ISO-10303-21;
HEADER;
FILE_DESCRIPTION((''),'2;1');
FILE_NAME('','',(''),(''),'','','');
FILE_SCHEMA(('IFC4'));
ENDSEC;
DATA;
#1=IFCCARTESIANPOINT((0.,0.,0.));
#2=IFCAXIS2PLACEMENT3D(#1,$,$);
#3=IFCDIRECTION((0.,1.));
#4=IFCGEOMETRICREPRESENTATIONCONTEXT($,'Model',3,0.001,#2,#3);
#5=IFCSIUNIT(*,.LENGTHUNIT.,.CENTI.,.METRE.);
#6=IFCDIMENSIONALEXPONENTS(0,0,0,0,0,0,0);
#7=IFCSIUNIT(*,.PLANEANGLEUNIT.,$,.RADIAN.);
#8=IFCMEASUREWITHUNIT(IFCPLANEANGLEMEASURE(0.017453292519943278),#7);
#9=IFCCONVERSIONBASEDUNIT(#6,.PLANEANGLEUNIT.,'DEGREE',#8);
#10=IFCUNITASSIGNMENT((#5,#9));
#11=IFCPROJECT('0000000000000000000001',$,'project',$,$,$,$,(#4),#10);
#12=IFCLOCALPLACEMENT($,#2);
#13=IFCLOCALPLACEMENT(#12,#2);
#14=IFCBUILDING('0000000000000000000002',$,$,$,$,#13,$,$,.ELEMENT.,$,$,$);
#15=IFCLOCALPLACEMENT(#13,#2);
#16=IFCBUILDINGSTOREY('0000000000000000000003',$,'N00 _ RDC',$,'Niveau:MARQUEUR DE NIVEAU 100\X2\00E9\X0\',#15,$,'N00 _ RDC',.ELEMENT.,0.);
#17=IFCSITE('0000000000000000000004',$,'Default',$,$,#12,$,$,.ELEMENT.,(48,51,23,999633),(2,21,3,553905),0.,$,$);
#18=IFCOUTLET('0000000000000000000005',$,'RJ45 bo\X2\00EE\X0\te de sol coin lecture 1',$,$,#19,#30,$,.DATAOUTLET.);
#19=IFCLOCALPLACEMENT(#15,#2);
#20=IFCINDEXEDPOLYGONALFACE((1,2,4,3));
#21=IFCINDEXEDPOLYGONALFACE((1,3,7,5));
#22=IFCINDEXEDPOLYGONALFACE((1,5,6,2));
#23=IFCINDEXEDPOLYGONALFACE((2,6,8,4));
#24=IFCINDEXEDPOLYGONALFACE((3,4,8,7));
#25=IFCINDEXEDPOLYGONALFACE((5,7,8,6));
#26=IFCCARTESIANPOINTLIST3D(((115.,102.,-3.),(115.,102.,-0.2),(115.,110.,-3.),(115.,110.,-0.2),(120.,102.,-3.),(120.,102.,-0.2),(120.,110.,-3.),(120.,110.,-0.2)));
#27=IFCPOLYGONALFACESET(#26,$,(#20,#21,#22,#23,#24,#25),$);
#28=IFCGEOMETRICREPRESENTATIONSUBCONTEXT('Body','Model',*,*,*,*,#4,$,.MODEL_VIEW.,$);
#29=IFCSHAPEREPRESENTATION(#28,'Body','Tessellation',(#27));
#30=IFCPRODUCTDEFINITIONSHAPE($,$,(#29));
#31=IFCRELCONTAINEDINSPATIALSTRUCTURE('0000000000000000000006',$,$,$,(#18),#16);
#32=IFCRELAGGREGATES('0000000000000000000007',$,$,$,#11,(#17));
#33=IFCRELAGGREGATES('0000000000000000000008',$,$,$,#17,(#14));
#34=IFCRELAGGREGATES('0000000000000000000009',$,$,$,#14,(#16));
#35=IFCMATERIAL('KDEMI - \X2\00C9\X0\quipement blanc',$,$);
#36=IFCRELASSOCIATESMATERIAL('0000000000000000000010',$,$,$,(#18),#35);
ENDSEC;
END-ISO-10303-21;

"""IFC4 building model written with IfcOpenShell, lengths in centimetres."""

from ifc_helpers import new_model, entity, si_unit, converted_unit, direction, frame, frame_2d, origin, origin_with_axes, place, context, subcontext, project, spatial, rectangle, extrude, material, element, save


model = new_model("IFC4")

# Units and contexts
model_context = context("Model", 3, precision=0.001, world=origin(), true_north=direction((0.0, 1.0)))
body_context = subcontext(model_context, "Body", "Model", "MODEL_VIEW")
ifc_project = project(units=[si_unit("LENGTHUNIT", "METRE", prefix="CENTI"), converted_unit("PLANEANGLEUNIT", "DEGREE", entity("IfcPlaneAngleMeasure", 0.017453292519943278), si_unit("PLANEANGLEUNIT", "RADIAN"), dimensions=[0, 0, 0, 0, 0, 0, 0])], contexts=[model_context])

# Site, building, storey
site_placement = place(None, origin())
site = spatial("IfcSite", under=ifc_project, at=site_placement, Name="Default", CompositionType="ELEMENT", RefLatitude=(48, 51, 23, 999633), RefLongitude=(2, 21, 3, 553905), RefElevation=0.0)
building_placement = place(site_placement, origin())
building = spatial("IfcBuilding", under=site, at=building_placement, CompositionType="ELEMENT")
storey_placement = place(building_placement, origin())
storey = spatial("IfcBuildingStorey", under=building, at=storey_placement, Name="N00 _ RDC", ObjectType="Niveau:MARQUEUR DE NIVEAU 100é", LongName="N00 _ RDC", CompositionType="ELEMENT", Elevation=0.0)

# Shared definitions
ifc_material_1 = material(Name="KDEMI - Équipement blanc")

# Outlet
outlet_1_placement = place(storey_placement, origin_with_axes())
element("IfcOutlet", 1, at=outlet_1_placement, inside=storey, material=ifc_material_1, Name="RJ45 boîte de sol coin lecture 1", PredefinedType="DATAOUTLET", context=body_context, shape_type="SweptSolid", body=[
    extrude(rectangle(XDim=5.0, YDim=8.0, at=frame_2d((117.5, 106.0))), frame((0.0, 0.0, -3.0)), (0.0, 0.0, 1.0), 2.8),
])

save(model, "model.ifc")
